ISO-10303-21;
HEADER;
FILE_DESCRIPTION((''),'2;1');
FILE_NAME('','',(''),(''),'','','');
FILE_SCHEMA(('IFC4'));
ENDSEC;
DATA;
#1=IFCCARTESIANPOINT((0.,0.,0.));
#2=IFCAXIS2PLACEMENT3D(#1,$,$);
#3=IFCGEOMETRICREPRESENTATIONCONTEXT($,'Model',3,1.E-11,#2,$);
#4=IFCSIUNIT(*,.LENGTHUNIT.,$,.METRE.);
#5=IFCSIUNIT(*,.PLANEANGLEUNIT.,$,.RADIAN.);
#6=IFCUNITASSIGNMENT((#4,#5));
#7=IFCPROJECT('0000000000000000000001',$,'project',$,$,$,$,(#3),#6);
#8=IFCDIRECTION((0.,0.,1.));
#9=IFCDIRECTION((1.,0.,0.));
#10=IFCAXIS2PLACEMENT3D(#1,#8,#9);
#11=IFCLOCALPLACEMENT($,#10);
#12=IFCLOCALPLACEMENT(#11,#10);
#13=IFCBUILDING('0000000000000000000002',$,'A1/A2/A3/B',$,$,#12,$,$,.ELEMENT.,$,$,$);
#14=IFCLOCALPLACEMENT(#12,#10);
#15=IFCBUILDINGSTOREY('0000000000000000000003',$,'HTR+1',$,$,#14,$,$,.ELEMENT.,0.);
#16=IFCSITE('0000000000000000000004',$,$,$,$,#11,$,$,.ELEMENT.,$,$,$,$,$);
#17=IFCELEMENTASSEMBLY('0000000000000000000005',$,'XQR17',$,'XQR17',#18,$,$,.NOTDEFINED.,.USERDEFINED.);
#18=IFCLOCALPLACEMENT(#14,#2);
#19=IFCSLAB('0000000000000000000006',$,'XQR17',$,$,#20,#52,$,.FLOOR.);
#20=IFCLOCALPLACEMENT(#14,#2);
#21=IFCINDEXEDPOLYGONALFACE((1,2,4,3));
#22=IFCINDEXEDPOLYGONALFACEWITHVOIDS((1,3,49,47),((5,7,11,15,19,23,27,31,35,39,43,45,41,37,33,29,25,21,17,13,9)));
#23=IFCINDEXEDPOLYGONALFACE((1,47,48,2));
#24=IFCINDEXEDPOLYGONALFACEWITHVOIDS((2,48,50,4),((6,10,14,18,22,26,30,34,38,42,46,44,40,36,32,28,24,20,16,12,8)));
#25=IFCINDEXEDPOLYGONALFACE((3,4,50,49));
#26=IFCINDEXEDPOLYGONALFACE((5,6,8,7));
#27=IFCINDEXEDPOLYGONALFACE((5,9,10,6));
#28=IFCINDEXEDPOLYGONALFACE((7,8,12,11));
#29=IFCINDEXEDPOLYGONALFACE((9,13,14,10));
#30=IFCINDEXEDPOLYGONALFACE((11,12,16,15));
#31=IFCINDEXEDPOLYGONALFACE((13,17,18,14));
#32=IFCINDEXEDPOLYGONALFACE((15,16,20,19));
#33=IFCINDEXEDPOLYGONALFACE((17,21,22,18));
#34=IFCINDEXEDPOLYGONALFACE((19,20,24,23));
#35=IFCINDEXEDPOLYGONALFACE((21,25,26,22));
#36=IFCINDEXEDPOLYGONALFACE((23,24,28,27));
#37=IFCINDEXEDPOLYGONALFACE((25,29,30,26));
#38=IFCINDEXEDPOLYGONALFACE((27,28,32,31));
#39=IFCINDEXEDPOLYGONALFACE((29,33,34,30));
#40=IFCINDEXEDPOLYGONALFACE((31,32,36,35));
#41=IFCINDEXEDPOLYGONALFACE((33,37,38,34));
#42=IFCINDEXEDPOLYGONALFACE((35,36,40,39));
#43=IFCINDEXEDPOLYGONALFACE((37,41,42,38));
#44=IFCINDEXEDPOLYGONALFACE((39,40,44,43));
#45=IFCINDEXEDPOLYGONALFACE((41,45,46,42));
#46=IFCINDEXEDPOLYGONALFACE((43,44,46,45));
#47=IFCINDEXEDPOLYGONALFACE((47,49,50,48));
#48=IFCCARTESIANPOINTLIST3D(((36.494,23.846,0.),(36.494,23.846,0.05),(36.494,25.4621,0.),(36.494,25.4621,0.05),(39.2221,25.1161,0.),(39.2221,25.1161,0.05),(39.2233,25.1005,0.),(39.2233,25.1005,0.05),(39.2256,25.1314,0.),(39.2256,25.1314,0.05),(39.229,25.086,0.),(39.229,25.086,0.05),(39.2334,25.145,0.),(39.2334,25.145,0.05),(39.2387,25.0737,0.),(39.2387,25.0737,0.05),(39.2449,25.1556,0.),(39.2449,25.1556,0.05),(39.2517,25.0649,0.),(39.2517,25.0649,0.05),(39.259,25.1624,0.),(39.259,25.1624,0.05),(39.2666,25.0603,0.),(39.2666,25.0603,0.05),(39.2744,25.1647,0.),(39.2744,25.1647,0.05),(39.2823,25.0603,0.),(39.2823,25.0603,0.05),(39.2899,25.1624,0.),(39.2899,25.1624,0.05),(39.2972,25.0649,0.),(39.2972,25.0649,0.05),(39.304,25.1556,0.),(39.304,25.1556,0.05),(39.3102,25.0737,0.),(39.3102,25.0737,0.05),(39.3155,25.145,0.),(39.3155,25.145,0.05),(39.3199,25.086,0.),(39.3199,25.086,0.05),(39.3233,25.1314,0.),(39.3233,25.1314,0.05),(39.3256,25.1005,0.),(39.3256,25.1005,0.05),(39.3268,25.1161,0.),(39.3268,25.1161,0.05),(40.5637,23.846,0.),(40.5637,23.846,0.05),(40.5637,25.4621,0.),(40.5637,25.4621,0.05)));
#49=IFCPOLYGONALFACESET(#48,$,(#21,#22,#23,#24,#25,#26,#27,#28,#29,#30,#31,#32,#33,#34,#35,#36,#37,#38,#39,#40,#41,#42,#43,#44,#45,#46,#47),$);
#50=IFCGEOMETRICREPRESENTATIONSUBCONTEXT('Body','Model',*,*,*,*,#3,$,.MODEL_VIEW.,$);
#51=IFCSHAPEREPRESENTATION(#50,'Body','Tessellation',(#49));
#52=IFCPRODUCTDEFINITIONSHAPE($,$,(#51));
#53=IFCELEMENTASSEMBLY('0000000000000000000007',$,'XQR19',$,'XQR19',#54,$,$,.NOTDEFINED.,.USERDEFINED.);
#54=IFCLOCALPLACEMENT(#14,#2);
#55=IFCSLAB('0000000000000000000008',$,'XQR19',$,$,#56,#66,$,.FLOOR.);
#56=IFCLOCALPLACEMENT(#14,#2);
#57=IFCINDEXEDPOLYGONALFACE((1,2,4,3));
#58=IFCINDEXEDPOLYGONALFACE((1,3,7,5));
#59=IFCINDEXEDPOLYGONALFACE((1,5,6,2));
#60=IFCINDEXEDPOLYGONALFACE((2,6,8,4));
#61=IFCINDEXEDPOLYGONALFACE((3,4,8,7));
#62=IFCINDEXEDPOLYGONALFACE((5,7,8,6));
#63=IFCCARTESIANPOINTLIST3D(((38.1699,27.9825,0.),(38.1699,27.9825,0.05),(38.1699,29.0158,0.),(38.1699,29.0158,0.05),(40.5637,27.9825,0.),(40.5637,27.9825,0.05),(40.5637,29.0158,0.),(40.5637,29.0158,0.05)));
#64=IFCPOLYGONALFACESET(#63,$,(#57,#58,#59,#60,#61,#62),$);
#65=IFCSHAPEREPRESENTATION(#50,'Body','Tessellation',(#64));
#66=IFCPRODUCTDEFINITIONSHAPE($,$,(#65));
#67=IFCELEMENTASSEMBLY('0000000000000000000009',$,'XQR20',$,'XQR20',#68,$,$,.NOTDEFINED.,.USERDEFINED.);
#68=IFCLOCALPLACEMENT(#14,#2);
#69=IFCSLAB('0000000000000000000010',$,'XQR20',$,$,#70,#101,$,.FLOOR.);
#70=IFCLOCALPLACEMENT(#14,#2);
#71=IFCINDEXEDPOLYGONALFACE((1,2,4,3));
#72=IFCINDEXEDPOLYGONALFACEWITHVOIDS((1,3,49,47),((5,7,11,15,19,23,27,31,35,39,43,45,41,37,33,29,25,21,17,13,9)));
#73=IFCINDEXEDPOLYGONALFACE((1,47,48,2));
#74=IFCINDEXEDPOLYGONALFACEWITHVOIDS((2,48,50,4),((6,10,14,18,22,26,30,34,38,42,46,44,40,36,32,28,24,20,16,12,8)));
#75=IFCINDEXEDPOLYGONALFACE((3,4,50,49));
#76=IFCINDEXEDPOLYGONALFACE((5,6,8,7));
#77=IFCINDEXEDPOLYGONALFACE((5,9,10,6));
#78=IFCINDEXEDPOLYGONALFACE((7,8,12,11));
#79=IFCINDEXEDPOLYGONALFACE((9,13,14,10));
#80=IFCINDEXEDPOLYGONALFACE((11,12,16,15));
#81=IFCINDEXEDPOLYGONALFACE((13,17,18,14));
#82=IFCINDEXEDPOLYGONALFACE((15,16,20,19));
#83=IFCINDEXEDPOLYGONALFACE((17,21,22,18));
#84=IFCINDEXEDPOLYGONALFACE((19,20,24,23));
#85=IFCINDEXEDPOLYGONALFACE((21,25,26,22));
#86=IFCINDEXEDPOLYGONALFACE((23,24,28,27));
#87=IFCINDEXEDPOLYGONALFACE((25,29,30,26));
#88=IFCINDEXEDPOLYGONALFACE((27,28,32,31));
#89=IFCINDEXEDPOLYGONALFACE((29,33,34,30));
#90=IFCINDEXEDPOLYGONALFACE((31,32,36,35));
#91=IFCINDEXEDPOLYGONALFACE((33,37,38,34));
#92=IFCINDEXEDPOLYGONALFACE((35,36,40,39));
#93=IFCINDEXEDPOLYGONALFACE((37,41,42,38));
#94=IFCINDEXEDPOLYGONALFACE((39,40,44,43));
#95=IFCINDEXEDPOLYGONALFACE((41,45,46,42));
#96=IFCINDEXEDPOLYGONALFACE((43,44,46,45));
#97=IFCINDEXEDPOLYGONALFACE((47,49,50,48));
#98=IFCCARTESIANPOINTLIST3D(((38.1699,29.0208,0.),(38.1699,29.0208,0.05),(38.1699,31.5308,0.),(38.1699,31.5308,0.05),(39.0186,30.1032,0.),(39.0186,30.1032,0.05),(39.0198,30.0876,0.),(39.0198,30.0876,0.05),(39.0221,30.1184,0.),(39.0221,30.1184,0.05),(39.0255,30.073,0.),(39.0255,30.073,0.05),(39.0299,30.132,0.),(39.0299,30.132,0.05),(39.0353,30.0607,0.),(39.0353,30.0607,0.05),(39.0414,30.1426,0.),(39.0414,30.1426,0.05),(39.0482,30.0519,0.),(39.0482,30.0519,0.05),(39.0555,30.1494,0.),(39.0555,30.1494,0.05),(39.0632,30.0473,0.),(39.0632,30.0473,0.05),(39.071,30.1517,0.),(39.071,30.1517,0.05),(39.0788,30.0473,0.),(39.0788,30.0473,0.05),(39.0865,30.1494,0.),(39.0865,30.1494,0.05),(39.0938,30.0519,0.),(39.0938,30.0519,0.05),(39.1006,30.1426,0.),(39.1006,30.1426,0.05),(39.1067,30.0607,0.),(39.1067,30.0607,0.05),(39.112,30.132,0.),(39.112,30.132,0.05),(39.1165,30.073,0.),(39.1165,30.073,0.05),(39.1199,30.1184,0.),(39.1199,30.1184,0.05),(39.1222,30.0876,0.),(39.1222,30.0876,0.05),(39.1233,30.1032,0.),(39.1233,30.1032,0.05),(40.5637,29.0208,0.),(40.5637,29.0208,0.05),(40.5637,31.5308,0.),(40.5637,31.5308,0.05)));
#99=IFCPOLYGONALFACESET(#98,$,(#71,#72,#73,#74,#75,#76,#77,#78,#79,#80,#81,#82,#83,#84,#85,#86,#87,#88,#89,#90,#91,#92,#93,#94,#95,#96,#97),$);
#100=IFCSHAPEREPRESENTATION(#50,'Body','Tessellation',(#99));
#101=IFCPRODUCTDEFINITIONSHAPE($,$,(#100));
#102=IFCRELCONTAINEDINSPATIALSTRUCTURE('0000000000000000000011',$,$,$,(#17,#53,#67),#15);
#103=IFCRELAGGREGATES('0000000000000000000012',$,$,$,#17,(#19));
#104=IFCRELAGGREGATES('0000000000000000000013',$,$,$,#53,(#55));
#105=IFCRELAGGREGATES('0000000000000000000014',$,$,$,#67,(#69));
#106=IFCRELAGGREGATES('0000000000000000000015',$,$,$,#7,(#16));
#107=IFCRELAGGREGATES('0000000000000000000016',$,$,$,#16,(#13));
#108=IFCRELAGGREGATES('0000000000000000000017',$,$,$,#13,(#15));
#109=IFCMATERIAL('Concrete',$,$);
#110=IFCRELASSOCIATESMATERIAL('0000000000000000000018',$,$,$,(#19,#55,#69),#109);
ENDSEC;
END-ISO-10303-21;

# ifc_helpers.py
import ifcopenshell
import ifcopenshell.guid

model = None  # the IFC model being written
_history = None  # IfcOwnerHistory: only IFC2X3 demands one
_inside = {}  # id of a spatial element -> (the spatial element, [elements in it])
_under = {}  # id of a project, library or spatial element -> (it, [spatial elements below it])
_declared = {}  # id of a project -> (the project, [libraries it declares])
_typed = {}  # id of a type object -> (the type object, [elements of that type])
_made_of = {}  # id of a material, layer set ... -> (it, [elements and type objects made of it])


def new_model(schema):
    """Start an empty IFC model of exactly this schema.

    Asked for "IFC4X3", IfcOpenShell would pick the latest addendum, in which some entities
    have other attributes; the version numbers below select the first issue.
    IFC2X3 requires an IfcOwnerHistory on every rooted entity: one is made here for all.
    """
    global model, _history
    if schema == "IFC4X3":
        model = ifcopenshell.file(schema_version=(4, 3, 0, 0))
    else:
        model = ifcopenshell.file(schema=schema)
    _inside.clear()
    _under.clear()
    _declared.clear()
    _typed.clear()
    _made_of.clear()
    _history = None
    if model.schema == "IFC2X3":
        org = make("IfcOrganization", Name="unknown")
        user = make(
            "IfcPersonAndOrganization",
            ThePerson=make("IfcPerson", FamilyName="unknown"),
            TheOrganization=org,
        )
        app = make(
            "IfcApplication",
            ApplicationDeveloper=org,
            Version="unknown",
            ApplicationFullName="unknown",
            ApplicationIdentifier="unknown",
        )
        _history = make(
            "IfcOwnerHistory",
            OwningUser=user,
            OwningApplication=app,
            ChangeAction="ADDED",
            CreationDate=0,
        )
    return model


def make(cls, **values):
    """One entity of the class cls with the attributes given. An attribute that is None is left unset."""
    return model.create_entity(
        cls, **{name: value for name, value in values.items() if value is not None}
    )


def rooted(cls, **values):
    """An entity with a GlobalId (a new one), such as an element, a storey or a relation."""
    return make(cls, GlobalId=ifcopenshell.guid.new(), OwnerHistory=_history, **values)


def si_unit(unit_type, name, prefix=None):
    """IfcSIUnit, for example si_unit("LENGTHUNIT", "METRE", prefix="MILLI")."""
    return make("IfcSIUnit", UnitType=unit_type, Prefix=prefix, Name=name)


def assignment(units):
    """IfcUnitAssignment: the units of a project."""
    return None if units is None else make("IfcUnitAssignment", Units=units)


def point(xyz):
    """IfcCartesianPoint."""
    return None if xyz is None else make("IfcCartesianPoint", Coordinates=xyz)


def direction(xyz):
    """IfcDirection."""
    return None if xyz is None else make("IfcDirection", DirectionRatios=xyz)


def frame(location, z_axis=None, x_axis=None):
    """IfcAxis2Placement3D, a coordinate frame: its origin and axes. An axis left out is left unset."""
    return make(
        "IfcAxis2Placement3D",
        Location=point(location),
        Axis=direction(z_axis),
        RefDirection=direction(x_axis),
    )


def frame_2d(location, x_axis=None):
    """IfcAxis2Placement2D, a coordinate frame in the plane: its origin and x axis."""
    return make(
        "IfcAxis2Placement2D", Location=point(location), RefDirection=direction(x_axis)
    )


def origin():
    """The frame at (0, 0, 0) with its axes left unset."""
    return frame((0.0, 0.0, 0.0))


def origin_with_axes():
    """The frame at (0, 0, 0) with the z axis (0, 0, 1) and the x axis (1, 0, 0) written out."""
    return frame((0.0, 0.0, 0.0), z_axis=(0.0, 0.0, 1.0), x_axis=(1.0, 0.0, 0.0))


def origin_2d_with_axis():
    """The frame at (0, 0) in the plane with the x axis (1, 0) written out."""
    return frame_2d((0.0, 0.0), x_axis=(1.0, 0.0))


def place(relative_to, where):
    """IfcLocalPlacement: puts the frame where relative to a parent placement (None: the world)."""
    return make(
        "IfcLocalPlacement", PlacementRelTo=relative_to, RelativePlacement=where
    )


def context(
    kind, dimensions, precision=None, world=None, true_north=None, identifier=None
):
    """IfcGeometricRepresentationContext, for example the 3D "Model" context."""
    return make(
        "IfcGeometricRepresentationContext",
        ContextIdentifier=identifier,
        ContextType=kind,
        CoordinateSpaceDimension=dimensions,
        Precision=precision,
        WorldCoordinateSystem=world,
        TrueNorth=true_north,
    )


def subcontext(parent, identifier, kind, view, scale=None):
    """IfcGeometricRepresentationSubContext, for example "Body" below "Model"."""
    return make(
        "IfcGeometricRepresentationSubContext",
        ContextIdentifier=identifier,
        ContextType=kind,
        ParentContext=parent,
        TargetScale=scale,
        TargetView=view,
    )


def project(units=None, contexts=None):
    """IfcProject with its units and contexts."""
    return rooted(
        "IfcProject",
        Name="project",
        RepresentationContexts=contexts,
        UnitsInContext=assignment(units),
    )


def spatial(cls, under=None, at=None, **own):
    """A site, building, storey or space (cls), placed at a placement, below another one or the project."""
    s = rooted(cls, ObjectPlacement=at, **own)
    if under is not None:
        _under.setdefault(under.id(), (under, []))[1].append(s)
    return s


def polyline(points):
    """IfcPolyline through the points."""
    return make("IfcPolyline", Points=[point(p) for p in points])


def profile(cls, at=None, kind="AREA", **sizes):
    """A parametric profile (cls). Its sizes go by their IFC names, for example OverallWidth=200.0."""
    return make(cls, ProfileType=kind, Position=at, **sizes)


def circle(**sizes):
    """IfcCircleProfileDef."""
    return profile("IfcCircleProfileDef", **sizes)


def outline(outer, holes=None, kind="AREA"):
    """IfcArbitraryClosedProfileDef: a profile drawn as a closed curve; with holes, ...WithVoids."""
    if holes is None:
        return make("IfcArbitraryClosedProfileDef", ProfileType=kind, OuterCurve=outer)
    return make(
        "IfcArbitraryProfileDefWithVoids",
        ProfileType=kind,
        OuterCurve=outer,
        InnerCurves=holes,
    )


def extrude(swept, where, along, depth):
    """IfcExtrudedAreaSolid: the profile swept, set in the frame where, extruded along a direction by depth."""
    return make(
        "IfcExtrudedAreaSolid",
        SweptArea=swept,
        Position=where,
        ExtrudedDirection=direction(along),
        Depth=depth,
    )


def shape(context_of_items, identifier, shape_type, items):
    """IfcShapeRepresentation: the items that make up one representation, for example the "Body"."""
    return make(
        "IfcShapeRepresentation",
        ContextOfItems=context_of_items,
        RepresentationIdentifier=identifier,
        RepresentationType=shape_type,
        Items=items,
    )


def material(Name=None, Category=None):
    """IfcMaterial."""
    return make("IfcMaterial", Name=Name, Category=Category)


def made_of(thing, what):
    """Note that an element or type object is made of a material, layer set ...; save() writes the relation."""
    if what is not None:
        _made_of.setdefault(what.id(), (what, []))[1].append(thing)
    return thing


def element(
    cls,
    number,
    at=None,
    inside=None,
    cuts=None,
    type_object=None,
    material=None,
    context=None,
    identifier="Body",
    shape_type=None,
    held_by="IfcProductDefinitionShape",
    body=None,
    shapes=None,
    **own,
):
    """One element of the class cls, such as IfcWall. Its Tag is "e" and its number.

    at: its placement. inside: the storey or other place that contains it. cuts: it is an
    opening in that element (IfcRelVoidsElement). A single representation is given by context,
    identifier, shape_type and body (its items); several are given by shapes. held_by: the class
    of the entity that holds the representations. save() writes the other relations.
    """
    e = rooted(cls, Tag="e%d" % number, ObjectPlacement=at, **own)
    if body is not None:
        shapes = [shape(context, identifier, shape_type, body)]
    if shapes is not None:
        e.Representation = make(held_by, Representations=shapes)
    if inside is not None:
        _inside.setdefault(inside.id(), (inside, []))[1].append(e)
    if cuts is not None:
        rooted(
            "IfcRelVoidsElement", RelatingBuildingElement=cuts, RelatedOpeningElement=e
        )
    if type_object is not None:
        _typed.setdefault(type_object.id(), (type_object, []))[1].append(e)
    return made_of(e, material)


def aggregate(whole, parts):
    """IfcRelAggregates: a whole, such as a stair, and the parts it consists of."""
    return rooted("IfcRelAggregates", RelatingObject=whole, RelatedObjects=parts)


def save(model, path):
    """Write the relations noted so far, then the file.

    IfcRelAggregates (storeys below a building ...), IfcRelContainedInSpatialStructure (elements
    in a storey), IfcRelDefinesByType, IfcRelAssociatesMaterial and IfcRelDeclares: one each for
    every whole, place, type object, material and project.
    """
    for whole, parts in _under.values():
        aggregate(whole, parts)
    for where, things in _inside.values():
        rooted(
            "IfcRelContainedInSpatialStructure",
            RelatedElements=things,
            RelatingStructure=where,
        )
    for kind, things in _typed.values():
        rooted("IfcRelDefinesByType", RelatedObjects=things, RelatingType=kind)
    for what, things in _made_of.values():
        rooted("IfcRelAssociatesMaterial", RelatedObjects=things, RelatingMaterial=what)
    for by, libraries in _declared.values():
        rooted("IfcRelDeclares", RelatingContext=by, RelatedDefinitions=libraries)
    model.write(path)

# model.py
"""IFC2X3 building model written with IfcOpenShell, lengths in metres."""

from ifc_helpers import new_model, si_unit, frame, origin, origin_with_axes, origin_2d_with_axis, place, context, subcontext, project, spatial, polyline, circle, outline, extrude, material, element, aggregate, save


model = new_model("IFC2X3")

# Units and contexts
model_context = context("Model", 3, precision=1e-11, world=origin())
body_context = subcontext(model_context, "Body", "Model", "MODEL_VIEW")
ifc_project = project(units=[si_unit("LENGTHUNIT", "METRE"), si_unit("PLANEANGLEUNIT", "RADIAN")], contexts=[model_context])

# Site, building, storey
site_placement = place(None, origin_with_axes())
site = spatial("IfcSite", under=ifc_project, at=site_placement, CompositionType="ELEMENT")
building_placement = place(site_placement, origin_with_axes())
building = spatial("IfcBuilding", under=site, at=building_placement, Name="A1/A2/A3/B", CompositionType="ELEMENT")
storey_placement = place(building_placement, origin_with_axes())
storey = spatial("IfcBuildingStorey", under=building, at=storey_placement, Name="HTR+1", CompositionType="ELEMENT", Elevation=0.0)

# Element assembly, slab, opening
assembly_1_placement = place(storey_placement, origin_with_axes())
assembly_1 = element("IfcElementAssembly", 1, at=assembly_1_placement, inside=storey, Name="XQR17", ObjectType="XQR17", AssemblyPlace="NOTDEFINED", PredefinedType="USERDEFINED")
ifc_material = material(Name="Concrete")
slab_1_placement = place(assembly_1_placement, frame((36.494, 23.846, 0.0), z_axis=(0.0, 0.0, 1.0), x_axis=(1.0, 0.0, 0.0)))
slab_1 = element("IfcSlab", 2, at=slab_1_placement, material=ifc_material, Name="XQR17", PredefinedType="FLOOR", context=body_context, shape_type="SweptSolid", body=[
    extrude(outline(polyline([(0.0, 0.0), (0.0, -4.0696), (1.616, -4.0696), (1.616, 0.0), (0.0, 0.0)])), frame((0.0, 0.0, 0.0), z_axis=(0.0, 0.0, 1.0), x_axis=(0.0, 1.0, 0.0)), (0.0, 0.0, 1.0), 0.05),
])
opening_1_placement = place(slab_1_placement, frame((2.7804, 1.2662, 0.0), z_axis=(0.0, 0.0, 1.0), x_axis=(1.0, 0.0, 0.0)))
element("IfcOpeningElement", 3, at=opening_1_placement, cuts=slab_1, ObjectType="Opening", context=body_context, shape_type="SweptSolid", body=[
    extrude(circle(Radius=0.0525, at=origin_2d_with_axis()), frame((0.0, 0.0, 0.0), z_axis=(0.0, 0.0, 1.0), x_axis=(0.0, 1.0, 0.0)), (0.0, 0.0, 1.0), 0.05),
])

# Element assembly, slab
assembly_2_placement = place(storey_placement, origin_with_axes())
assembly_2 = element("IfcElementAssembly", 4, at=assembly_2_placement, inside=storey, Name="XQR19", ObjectType="XQR19", AssemblyPlace="NOTDEFINED", PredefinedType="USERDEFINED")
slab_2_placement = place(assembly_2_placement, frame((38.1699, 27.9825, 0.0), z_axis=(0.0, 0.0, 1.0), x_axis=(1.0, 0.0, 0.0)))
slab_2 = element("IfcSlab", 5, at=slab_2_placement, material=ifc_material, Name="XQR19", PredefinedType="FLOOR", context=body_context, shape_type="SweptSolid", body=[
    extrude(outline(polyline([(0.0, 0.0), (0.0, -2.3938), (1.0333, -2.3938), (1.0333, 0.0), (0.0, 0.0)])), frame((0.0, 0.0, 0.0), z_axis=(0.0, 0.0, 1.0), x_axis=(0.0, 1.0, 0.0)), (0.0, 0.0, 1.0), 0.05),
])

# Element assembly, slab, opening
assembly_3_placement = place(storey_placement, origin_with_axes())
assembly_3 = element("IfcElementAssembly", 6, at=assembly_3_placement, inside=storey, Name="XQR20", ObjectType="XQR20", AssemblyPlace="NOTDEFINED", PredefinedType="USERDEFINED")
slab_3_placement = place(assembly_3_placement, frame((38.1699, 29.0208, 0.0), z_axis=(0.0, 0.0, 1.0), x_axis=(1.0, 0.0, 0.0)))
slab_3 = element("IfcSlab", 7, at=slab_3_placement, material=ifc_material, Name="XQR20", PredefinedType="FLOOR", context=body_context, shape_type="SweptSolid", body=[
    extrude(outline(polyline([(0.0, 0.0), (0.0, -2.3938), (2.51, -2.3938), (2.51, 0.0), (0.0, 0.0)])), frame((0.0, 0.0, 0.0), z_axis=(0.0, 0.0, 1.0), x_axis=(0.0, 1.0, 0.0)), (0.0, 0.0, 1.0), 0.05),
])
opening_2_placement = place(slab_3_placement, frame((0.9011, 1.0784, 0.0), z_axis=(0.0, 0.0, 1.0), x_axis=(1.0, 0.0, 0.0)))
element("IfcOpeningElement", 8, at=opening_2_placement, cuts=slab_3, ObjectType="Opening", context=body_context, shape_type="SweptSolid", body=[
    extrude(circle(Radius=0.0525, at=origin_2d_with_axis()), frame((0.0, 0.0, 0.0), z_axis=(0.0, 0.0, 1.0), x_axis=(0.0, 1.0, 0.0)), (0.0, 0.0, 1.0), 0.05),
])

aggregate(assembly_1, [slab_1])

aggregate(assembly_2, [slab_2])

aggregate(assembly_3, [slab_3])

save(model, "model.ifc")
